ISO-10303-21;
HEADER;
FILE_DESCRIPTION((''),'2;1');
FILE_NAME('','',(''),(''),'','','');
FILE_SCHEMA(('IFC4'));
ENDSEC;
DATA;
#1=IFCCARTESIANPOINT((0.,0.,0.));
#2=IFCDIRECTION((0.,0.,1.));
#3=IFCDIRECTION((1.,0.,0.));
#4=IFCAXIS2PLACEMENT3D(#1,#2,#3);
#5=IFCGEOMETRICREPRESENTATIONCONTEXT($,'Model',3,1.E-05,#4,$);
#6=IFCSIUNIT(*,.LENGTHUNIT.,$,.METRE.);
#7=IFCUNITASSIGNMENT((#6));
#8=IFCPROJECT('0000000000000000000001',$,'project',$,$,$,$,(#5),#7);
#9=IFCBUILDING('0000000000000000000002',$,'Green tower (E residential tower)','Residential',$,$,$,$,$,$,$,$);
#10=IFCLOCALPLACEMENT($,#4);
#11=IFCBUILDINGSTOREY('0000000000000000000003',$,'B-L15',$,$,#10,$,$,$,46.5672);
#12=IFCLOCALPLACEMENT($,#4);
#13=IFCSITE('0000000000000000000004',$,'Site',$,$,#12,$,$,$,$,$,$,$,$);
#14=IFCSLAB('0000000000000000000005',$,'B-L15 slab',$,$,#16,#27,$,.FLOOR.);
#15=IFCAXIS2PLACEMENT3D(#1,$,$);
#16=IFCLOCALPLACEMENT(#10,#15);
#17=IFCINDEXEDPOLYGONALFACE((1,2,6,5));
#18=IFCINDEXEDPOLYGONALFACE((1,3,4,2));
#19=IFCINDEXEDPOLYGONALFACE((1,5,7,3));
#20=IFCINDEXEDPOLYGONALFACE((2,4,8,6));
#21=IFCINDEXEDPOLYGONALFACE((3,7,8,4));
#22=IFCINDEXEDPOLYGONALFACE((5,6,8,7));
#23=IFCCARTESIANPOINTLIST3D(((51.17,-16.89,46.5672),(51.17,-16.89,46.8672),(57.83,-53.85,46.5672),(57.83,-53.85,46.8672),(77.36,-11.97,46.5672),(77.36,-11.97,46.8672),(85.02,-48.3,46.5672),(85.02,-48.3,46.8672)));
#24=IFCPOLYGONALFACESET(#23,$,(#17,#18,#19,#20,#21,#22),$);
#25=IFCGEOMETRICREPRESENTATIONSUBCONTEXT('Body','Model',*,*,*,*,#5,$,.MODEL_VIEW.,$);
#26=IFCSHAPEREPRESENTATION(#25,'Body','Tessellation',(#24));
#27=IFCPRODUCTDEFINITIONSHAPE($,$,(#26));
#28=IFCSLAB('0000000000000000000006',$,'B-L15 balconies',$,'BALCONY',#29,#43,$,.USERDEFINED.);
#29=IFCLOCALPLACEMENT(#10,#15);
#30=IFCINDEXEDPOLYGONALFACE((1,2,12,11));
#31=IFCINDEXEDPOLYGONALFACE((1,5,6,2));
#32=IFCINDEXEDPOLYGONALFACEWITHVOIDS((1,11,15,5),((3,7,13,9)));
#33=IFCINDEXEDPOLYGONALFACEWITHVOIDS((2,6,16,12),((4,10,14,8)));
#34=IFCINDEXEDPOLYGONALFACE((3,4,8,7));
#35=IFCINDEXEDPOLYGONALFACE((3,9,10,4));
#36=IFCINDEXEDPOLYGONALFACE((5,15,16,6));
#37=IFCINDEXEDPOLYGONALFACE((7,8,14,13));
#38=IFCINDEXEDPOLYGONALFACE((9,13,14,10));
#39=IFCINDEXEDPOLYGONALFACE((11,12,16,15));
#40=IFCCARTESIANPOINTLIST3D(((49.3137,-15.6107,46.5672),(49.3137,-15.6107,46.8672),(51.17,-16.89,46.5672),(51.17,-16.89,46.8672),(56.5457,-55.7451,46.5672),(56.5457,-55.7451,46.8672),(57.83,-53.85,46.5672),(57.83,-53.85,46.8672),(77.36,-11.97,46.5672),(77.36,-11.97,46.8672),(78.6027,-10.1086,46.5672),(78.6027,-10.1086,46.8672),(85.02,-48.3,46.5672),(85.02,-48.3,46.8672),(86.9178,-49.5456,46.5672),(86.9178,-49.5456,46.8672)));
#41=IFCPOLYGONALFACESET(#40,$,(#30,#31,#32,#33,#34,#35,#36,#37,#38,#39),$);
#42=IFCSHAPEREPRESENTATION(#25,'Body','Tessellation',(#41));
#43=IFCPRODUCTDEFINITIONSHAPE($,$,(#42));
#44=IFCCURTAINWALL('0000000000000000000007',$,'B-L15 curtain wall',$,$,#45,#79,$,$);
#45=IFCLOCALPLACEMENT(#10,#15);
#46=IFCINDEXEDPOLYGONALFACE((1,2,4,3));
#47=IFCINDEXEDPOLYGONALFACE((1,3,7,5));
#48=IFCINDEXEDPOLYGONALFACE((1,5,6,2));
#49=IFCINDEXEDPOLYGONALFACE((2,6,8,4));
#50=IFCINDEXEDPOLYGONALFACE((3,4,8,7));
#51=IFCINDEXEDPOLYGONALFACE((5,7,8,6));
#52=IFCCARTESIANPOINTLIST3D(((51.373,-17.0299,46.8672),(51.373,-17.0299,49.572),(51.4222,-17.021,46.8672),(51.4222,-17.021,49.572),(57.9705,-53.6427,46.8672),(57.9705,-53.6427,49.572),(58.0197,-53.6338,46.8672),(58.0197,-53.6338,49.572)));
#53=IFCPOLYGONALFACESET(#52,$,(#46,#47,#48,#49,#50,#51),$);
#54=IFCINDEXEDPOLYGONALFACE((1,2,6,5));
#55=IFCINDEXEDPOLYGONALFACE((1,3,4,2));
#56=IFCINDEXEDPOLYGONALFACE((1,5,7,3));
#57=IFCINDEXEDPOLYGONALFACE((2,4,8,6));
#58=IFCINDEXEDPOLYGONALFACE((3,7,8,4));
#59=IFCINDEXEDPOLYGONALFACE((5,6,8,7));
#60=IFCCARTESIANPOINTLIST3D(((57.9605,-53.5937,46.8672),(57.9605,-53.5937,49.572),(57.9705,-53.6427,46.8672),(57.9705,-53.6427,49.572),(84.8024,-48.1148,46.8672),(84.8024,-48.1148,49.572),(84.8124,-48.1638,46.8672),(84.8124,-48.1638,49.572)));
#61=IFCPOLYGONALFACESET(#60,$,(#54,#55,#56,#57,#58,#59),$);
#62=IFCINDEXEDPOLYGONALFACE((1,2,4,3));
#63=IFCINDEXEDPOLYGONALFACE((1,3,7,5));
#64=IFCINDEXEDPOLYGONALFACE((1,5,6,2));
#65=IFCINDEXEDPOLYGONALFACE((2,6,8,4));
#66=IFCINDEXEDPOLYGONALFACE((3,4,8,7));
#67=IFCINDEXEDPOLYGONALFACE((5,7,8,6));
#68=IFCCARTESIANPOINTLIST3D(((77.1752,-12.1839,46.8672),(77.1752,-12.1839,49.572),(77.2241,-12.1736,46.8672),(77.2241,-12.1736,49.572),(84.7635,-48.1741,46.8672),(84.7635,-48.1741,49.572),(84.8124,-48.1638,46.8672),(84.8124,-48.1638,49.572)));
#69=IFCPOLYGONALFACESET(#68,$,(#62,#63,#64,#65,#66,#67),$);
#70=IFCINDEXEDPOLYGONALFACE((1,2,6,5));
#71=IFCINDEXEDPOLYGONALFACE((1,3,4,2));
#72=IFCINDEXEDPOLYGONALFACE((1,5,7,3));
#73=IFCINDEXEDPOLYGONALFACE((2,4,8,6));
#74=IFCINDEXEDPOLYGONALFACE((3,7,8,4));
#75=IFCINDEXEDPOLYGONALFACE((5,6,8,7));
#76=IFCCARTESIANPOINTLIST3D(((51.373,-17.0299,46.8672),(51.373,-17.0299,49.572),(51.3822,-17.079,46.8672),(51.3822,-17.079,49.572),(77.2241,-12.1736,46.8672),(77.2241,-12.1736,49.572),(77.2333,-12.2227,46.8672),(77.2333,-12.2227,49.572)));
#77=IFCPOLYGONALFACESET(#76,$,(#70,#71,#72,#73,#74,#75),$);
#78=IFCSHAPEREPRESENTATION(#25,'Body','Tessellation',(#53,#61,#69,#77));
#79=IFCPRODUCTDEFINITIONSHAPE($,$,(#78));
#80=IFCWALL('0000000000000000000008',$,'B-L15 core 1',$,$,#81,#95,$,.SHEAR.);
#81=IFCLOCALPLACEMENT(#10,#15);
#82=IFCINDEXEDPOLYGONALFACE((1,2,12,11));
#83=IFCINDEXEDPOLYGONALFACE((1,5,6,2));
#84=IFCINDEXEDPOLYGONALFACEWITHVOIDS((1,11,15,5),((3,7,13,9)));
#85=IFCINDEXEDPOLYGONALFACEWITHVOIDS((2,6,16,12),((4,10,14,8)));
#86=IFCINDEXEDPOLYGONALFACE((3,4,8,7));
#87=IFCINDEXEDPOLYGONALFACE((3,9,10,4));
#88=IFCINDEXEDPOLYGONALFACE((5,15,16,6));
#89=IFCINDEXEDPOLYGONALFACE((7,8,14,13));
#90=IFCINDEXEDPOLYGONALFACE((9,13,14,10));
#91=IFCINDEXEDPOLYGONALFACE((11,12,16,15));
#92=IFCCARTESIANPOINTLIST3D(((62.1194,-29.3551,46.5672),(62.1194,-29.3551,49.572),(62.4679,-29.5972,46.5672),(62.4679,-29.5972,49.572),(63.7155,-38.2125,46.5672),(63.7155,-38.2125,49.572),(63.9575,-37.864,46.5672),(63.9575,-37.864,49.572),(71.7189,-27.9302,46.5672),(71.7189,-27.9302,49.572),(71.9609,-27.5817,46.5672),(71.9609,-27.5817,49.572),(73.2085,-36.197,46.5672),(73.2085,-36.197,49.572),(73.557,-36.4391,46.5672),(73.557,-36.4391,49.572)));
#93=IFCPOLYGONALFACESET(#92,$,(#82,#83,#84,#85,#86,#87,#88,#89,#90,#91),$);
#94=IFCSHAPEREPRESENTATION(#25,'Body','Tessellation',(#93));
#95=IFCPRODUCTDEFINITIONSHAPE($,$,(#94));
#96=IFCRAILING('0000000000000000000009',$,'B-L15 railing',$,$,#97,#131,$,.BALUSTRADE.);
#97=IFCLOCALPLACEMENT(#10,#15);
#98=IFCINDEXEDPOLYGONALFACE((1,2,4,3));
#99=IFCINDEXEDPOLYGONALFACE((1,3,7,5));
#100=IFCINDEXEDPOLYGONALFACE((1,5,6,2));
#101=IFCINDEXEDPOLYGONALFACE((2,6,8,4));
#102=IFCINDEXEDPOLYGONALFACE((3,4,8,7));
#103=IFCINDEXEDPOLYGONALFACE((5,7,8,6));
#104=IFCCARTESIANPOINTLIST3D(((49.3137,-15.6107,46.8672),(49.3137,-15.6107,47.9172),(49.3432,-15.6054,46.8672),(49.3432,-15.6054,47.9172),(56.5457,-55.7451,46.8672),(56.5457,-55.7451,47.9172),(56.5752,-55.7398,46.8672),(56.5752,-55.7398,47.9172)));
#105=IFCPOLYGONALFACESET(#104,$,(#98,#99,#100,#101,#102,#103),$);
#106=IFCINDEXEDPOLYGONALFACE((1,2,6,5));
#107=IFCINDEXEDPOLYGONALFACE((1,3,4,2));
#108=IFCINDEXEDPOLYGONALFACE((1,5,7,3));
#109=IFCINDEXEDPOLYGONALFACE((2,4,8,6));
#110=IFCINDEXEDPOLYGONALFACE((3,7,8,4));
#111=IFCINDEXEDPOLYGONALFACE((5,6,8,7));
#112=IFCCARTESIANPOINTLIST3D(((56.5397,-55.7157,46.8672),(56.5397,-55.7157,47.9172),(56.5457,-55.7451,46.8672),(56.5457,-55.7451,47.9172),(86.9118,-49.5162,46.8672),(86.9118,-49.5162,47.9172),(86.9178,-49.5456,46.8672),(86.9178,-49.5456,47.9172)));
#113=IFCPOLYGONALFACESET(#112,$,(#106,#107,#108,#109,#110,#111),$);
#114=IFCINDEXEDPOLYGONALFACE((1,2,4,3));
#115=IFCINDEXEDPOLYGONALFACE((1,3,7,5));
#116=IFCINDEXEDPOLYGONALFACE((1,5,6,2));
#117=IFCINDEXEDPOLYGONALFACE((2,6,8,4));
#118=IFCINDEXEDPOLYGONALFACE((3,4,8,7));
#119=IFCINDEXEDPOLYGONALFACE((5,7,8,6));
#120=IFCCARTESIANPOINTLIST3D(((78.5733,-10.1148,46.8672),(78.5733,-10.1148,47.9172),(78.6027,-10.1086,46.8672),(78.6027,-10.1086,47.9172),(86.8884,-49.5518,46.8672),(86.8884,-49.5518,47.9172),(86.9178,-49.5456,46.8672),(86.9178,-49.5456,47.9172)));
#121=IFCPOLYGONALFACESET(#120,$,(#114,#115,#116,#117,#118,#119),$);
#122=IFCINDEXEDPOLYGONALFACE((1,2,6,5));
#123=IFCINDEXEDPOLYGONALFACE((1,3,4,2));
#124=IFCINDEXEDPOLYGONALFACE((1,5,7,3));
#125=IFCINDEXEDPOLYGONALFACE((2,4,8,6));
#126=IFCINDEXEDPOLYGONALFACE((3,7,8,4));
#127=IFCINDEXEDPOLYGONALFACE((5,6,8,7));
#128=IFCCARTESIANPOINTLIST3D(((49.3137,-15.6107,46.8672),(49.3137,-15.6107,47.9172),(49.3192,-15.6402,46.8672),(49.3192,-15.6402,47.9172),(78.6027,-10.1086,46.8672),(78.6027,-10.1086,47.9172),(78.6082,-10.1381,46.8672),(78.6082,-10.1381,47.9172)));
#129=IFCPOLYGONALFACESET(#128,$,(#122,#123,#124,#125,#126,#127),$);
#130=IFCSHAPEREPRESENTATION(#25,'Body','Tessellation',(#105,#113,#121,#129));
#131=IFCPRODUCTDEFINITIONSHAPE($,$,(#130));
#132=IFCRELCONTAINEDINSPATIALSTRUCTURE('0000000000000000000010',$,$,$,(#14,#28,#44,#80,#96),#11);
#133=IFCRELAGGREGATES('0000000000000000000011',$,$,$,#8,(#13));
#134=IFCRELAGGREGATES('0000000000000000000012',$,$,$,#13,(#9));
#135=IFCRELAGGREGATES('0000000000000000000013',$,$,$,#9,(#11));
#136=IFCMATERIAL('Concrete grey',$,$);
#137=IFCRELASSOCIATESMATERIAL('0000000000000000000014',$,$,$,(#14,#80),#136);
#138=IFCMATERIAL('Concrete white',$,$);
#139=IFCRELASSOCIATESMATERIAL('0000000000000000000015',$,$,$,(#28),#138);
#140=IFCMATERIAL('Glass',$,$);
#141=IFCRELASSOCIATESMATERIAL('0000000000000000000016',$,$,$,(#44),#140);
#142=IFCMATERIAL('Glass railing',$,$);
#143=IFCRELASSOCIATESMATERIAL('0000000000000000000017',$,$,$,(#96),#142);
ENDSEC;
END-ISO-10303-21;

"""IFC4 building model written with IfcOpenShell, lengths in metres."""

from ifc_helpers import new_model, si_unit, frame, origin_with_axes, place, context, subcontext, project, spatial, polyline, outline, extrude, material, element, save


model = new_model("IFC4")

# Units and contexts
model_context = context("Model", 3, precision=1e-05, world=origin_with_axes())
body_context = subcontext(model_context, "Body", "Model", "MODEL_VIEW")
ifc_project = project(units=[si_unit("LENGTHUNIT", "METRE")], contexts=[model_context])

# Site, building, storey
site_placement = place(None, origin_with_axes())
site = spatial("IfcSite", under=ifc_project, at=site_placement, Name="Site")
building = spatial("IfcBuilding", under=site, Name="Green tower (E residential tower)", Description="Residential")
storey_placement = place(None, origin_with_axes())
storey = spatial("IfcBuildingStorey", under=building, at=storey_placement, Name="B-L15", Elevation=46.5672)

# Slabs
ifc_material_1 = material(Name="Concrete grey")
slab_1_placement = place(storey_placement, origin_with_axes())
element("IfcSlab", 1, at=slab_1_placement, inside=storey, material=ifc_material_1, Name="B-L15 slab", PredefinedType="FLOOR", context=body_context, shape_type="SweptSolid", body=[
    extrude(outline(polyline([(51.17, -16.89), (57.83, -53.85), (85.02, -48.3), (77.36, -11.97), (51.17, -16.89)])), frame((0.0, 0.0, 46.5672), z_axis=(0.0, 0.0, 1.0), x_axis=(1.0, 0.0, 0.0)), (0.0, 0.0, 1.0), 0.3),
])
ifc_material_2 = material(Name="Concrete white")
slab_2_placement = place(storey_placement, origin_with_axes())
element("IfcSlab", 2, at=slab_2_placement, inside=storey, material=ifc_material_2, Name="B-L15 balconies", ObjectType="BALCONY", PredefinedType="USERDEFINED", context=body_context, shape_type="SweptSolid", body=[
    extrude(outline(polyline([(49.3137, -15.6107), (56.5457, -55.7451), (86.9178, -49.5456), (78.6027, -10.1086), (49.3137, -15.6107)]), holes=[polyline([(51.17, -16.89), (57.83, -53.85), (85.02, -48.3), (77.36, -11.97), (51.17, -16.89)])]), frame((0.0, 0.0, 46.5672), z_axis=(0.0, 0.0, 1.0), x_axis=(1.0, 0.0, 0.0)), (0.0, 0.0, 1.0), 0.3),
])

# Curtain wall
ifc_material_3 = material(Name="Glass")
curtain_wall_placement = place(storey_placement, origin_with_axes())
element("IfcCurtainWall", 3, at=curtain_wall_placement, inside=storey, material=ifc_material_3, Name="B-L15 curtain wall", context=body_context, shape_type="SweptSolid", body=[
    extrude(outline(polyline([(51.373, -17.0299), (57.9705, -53.6427), (58.0197, -53.6338), (51.4222, -17.021), (51.373, -17.0299)])), frame((0.0, 0.0, 46.8672), z_axis=(0.0, 0.0, 1.0), x_axis=(1.0, 0.0, 0.0)), (0.0, 0.0, 1.0), 2.7048),
    extrude(outline(polyline([(57.9705, -53.6427), (84.8124, -48.1638), (84.8024, -48.1148), (57.9605, -53.5937), (57.9705, -53.6427)])), frame((0.0, 0.0, 46.8672), z_axis=(0.0, 0.0, 1.0), x_axis=(1.0, 0.0, 0.0)), (0.0, 0.0, 1.0), 2.7048),
    extrude(outline(polyline([(84.8124, -48.1638), (77.2241, -12.1736), (77.1752, -12.1839), (84.7635, -48.1741), (84.8124, -48.1638)])), frame((0.0, 0.0, 46.8672), z_axis=(0.0, 0.0, 1.0), x_axis=(1.0, 0.0, 0.0)), (0.0, 0.0, 1.0), 2.7048),
    extrude(outline(polyline([(77.2241, -12.1736), (51.373, -17.0299), (51.3822, -17.079), (77.2333, -12.2227), (77.2241, -12.1736)])), frame((0.0, 0.0, 46.8672), z_axis=(0.0, 0.0, 1.0), x_axis=(1.0, 0.0, 0.0)), (0.0, 0.0, 1.0), 2.7048),
])

# Wall
wall_placement = place(storey_placement, origin_with_axes())
element("IfcWall", 4, at=wall_placement, inside=storey, material=ifc_material_1, Name="B-L15 core 1", PredefinedType="SHEAR", context=body_context, shape_type="SweptSolid", body=[
    extrude(outline(polyline([(62.1194, -29.3551), (63.7155, -38.2125), (73.557, -36.4391), (71.9609, -27.5817), (62.1194, -29.3551)]), holes=[polyline([(62.4679, -29.5972), (63.9575, -37.864), (73.2085, -36.197), (71.7189, -27.9302), (62.4679, -29.5972)])]), frame((0.0, 0.0, 46.5672), z_axis=(0.0, 0.0, 1.0), x_axis=(1.0, 0.0, 0.0)), (0.0, 0.0, 1.0), 3.0048),
])

# Railing
ifc_material_4 = material(Name="Glass railing")
railing_placement = place(storey_placement, origin_with_axes())
element("IfcRailing", 5, at=railing_placement, inside=storey, material=ifc_material_4, Name="B-L15 railing", PredefinedType="BALUSTRADE", context=body_context, shape_type="SweptSolid", body=[
    extrude(outline(polyline([(49.3137, -15.6107), (56.5457, -55.7451), (56.5752, -55.7398), (49.3432, -15.6054), (49.3137, -15.6107)])), frame((0.0, 0.0, 46.8672), z_axis=(0.0, 0.0, 1.0), x_axis=(1.0, 0.0, 0.0)), (0.0, 0.0, 1.0), 1.05),
    extrude(outline(polyline([(56.5457, -55.7451), (86.9178, -49.5456), (86.9118, -49.5162), (56.5397, -55.7157), (56.5457, -55.7451)])), frame((0.0, 0.0, 46.8672), z_axis=(0.0, 0.0, 1.0), x_axis=(1.0, 0.0, 0.0)), (0.0, 0.0, 1.0), 1.05),
    extrude(outline(polyline([(86.9178, -49.5456), (78.6027, -10.1086), (78.5733, -10.1148), (86.8884, -49.5518), (86.9178, -49.5456)])), frame((0.0, 0.0, 46.8672), z_axis=(0.0, 0.0, 1.0), x_axis=(1.0, 0.0, 0.0)), (0.0, 0.0, 1.0), 1.05),
    extrude(outline(polyline([(78.6027, -10.1086), (49.3137, -15.6107), (49.3192, -15.6402), (78.6082, -10.1381), (78.6027, -10.1086)])), frame((0.0, 0.0, 46.8672), z_axis=(0.0, 0.0, 1.0), x_axis=(1.0, 0.0, 0.0)), (0.0, 0.0, 1.0), 1.05),
])

save(model, "model.ifc")
